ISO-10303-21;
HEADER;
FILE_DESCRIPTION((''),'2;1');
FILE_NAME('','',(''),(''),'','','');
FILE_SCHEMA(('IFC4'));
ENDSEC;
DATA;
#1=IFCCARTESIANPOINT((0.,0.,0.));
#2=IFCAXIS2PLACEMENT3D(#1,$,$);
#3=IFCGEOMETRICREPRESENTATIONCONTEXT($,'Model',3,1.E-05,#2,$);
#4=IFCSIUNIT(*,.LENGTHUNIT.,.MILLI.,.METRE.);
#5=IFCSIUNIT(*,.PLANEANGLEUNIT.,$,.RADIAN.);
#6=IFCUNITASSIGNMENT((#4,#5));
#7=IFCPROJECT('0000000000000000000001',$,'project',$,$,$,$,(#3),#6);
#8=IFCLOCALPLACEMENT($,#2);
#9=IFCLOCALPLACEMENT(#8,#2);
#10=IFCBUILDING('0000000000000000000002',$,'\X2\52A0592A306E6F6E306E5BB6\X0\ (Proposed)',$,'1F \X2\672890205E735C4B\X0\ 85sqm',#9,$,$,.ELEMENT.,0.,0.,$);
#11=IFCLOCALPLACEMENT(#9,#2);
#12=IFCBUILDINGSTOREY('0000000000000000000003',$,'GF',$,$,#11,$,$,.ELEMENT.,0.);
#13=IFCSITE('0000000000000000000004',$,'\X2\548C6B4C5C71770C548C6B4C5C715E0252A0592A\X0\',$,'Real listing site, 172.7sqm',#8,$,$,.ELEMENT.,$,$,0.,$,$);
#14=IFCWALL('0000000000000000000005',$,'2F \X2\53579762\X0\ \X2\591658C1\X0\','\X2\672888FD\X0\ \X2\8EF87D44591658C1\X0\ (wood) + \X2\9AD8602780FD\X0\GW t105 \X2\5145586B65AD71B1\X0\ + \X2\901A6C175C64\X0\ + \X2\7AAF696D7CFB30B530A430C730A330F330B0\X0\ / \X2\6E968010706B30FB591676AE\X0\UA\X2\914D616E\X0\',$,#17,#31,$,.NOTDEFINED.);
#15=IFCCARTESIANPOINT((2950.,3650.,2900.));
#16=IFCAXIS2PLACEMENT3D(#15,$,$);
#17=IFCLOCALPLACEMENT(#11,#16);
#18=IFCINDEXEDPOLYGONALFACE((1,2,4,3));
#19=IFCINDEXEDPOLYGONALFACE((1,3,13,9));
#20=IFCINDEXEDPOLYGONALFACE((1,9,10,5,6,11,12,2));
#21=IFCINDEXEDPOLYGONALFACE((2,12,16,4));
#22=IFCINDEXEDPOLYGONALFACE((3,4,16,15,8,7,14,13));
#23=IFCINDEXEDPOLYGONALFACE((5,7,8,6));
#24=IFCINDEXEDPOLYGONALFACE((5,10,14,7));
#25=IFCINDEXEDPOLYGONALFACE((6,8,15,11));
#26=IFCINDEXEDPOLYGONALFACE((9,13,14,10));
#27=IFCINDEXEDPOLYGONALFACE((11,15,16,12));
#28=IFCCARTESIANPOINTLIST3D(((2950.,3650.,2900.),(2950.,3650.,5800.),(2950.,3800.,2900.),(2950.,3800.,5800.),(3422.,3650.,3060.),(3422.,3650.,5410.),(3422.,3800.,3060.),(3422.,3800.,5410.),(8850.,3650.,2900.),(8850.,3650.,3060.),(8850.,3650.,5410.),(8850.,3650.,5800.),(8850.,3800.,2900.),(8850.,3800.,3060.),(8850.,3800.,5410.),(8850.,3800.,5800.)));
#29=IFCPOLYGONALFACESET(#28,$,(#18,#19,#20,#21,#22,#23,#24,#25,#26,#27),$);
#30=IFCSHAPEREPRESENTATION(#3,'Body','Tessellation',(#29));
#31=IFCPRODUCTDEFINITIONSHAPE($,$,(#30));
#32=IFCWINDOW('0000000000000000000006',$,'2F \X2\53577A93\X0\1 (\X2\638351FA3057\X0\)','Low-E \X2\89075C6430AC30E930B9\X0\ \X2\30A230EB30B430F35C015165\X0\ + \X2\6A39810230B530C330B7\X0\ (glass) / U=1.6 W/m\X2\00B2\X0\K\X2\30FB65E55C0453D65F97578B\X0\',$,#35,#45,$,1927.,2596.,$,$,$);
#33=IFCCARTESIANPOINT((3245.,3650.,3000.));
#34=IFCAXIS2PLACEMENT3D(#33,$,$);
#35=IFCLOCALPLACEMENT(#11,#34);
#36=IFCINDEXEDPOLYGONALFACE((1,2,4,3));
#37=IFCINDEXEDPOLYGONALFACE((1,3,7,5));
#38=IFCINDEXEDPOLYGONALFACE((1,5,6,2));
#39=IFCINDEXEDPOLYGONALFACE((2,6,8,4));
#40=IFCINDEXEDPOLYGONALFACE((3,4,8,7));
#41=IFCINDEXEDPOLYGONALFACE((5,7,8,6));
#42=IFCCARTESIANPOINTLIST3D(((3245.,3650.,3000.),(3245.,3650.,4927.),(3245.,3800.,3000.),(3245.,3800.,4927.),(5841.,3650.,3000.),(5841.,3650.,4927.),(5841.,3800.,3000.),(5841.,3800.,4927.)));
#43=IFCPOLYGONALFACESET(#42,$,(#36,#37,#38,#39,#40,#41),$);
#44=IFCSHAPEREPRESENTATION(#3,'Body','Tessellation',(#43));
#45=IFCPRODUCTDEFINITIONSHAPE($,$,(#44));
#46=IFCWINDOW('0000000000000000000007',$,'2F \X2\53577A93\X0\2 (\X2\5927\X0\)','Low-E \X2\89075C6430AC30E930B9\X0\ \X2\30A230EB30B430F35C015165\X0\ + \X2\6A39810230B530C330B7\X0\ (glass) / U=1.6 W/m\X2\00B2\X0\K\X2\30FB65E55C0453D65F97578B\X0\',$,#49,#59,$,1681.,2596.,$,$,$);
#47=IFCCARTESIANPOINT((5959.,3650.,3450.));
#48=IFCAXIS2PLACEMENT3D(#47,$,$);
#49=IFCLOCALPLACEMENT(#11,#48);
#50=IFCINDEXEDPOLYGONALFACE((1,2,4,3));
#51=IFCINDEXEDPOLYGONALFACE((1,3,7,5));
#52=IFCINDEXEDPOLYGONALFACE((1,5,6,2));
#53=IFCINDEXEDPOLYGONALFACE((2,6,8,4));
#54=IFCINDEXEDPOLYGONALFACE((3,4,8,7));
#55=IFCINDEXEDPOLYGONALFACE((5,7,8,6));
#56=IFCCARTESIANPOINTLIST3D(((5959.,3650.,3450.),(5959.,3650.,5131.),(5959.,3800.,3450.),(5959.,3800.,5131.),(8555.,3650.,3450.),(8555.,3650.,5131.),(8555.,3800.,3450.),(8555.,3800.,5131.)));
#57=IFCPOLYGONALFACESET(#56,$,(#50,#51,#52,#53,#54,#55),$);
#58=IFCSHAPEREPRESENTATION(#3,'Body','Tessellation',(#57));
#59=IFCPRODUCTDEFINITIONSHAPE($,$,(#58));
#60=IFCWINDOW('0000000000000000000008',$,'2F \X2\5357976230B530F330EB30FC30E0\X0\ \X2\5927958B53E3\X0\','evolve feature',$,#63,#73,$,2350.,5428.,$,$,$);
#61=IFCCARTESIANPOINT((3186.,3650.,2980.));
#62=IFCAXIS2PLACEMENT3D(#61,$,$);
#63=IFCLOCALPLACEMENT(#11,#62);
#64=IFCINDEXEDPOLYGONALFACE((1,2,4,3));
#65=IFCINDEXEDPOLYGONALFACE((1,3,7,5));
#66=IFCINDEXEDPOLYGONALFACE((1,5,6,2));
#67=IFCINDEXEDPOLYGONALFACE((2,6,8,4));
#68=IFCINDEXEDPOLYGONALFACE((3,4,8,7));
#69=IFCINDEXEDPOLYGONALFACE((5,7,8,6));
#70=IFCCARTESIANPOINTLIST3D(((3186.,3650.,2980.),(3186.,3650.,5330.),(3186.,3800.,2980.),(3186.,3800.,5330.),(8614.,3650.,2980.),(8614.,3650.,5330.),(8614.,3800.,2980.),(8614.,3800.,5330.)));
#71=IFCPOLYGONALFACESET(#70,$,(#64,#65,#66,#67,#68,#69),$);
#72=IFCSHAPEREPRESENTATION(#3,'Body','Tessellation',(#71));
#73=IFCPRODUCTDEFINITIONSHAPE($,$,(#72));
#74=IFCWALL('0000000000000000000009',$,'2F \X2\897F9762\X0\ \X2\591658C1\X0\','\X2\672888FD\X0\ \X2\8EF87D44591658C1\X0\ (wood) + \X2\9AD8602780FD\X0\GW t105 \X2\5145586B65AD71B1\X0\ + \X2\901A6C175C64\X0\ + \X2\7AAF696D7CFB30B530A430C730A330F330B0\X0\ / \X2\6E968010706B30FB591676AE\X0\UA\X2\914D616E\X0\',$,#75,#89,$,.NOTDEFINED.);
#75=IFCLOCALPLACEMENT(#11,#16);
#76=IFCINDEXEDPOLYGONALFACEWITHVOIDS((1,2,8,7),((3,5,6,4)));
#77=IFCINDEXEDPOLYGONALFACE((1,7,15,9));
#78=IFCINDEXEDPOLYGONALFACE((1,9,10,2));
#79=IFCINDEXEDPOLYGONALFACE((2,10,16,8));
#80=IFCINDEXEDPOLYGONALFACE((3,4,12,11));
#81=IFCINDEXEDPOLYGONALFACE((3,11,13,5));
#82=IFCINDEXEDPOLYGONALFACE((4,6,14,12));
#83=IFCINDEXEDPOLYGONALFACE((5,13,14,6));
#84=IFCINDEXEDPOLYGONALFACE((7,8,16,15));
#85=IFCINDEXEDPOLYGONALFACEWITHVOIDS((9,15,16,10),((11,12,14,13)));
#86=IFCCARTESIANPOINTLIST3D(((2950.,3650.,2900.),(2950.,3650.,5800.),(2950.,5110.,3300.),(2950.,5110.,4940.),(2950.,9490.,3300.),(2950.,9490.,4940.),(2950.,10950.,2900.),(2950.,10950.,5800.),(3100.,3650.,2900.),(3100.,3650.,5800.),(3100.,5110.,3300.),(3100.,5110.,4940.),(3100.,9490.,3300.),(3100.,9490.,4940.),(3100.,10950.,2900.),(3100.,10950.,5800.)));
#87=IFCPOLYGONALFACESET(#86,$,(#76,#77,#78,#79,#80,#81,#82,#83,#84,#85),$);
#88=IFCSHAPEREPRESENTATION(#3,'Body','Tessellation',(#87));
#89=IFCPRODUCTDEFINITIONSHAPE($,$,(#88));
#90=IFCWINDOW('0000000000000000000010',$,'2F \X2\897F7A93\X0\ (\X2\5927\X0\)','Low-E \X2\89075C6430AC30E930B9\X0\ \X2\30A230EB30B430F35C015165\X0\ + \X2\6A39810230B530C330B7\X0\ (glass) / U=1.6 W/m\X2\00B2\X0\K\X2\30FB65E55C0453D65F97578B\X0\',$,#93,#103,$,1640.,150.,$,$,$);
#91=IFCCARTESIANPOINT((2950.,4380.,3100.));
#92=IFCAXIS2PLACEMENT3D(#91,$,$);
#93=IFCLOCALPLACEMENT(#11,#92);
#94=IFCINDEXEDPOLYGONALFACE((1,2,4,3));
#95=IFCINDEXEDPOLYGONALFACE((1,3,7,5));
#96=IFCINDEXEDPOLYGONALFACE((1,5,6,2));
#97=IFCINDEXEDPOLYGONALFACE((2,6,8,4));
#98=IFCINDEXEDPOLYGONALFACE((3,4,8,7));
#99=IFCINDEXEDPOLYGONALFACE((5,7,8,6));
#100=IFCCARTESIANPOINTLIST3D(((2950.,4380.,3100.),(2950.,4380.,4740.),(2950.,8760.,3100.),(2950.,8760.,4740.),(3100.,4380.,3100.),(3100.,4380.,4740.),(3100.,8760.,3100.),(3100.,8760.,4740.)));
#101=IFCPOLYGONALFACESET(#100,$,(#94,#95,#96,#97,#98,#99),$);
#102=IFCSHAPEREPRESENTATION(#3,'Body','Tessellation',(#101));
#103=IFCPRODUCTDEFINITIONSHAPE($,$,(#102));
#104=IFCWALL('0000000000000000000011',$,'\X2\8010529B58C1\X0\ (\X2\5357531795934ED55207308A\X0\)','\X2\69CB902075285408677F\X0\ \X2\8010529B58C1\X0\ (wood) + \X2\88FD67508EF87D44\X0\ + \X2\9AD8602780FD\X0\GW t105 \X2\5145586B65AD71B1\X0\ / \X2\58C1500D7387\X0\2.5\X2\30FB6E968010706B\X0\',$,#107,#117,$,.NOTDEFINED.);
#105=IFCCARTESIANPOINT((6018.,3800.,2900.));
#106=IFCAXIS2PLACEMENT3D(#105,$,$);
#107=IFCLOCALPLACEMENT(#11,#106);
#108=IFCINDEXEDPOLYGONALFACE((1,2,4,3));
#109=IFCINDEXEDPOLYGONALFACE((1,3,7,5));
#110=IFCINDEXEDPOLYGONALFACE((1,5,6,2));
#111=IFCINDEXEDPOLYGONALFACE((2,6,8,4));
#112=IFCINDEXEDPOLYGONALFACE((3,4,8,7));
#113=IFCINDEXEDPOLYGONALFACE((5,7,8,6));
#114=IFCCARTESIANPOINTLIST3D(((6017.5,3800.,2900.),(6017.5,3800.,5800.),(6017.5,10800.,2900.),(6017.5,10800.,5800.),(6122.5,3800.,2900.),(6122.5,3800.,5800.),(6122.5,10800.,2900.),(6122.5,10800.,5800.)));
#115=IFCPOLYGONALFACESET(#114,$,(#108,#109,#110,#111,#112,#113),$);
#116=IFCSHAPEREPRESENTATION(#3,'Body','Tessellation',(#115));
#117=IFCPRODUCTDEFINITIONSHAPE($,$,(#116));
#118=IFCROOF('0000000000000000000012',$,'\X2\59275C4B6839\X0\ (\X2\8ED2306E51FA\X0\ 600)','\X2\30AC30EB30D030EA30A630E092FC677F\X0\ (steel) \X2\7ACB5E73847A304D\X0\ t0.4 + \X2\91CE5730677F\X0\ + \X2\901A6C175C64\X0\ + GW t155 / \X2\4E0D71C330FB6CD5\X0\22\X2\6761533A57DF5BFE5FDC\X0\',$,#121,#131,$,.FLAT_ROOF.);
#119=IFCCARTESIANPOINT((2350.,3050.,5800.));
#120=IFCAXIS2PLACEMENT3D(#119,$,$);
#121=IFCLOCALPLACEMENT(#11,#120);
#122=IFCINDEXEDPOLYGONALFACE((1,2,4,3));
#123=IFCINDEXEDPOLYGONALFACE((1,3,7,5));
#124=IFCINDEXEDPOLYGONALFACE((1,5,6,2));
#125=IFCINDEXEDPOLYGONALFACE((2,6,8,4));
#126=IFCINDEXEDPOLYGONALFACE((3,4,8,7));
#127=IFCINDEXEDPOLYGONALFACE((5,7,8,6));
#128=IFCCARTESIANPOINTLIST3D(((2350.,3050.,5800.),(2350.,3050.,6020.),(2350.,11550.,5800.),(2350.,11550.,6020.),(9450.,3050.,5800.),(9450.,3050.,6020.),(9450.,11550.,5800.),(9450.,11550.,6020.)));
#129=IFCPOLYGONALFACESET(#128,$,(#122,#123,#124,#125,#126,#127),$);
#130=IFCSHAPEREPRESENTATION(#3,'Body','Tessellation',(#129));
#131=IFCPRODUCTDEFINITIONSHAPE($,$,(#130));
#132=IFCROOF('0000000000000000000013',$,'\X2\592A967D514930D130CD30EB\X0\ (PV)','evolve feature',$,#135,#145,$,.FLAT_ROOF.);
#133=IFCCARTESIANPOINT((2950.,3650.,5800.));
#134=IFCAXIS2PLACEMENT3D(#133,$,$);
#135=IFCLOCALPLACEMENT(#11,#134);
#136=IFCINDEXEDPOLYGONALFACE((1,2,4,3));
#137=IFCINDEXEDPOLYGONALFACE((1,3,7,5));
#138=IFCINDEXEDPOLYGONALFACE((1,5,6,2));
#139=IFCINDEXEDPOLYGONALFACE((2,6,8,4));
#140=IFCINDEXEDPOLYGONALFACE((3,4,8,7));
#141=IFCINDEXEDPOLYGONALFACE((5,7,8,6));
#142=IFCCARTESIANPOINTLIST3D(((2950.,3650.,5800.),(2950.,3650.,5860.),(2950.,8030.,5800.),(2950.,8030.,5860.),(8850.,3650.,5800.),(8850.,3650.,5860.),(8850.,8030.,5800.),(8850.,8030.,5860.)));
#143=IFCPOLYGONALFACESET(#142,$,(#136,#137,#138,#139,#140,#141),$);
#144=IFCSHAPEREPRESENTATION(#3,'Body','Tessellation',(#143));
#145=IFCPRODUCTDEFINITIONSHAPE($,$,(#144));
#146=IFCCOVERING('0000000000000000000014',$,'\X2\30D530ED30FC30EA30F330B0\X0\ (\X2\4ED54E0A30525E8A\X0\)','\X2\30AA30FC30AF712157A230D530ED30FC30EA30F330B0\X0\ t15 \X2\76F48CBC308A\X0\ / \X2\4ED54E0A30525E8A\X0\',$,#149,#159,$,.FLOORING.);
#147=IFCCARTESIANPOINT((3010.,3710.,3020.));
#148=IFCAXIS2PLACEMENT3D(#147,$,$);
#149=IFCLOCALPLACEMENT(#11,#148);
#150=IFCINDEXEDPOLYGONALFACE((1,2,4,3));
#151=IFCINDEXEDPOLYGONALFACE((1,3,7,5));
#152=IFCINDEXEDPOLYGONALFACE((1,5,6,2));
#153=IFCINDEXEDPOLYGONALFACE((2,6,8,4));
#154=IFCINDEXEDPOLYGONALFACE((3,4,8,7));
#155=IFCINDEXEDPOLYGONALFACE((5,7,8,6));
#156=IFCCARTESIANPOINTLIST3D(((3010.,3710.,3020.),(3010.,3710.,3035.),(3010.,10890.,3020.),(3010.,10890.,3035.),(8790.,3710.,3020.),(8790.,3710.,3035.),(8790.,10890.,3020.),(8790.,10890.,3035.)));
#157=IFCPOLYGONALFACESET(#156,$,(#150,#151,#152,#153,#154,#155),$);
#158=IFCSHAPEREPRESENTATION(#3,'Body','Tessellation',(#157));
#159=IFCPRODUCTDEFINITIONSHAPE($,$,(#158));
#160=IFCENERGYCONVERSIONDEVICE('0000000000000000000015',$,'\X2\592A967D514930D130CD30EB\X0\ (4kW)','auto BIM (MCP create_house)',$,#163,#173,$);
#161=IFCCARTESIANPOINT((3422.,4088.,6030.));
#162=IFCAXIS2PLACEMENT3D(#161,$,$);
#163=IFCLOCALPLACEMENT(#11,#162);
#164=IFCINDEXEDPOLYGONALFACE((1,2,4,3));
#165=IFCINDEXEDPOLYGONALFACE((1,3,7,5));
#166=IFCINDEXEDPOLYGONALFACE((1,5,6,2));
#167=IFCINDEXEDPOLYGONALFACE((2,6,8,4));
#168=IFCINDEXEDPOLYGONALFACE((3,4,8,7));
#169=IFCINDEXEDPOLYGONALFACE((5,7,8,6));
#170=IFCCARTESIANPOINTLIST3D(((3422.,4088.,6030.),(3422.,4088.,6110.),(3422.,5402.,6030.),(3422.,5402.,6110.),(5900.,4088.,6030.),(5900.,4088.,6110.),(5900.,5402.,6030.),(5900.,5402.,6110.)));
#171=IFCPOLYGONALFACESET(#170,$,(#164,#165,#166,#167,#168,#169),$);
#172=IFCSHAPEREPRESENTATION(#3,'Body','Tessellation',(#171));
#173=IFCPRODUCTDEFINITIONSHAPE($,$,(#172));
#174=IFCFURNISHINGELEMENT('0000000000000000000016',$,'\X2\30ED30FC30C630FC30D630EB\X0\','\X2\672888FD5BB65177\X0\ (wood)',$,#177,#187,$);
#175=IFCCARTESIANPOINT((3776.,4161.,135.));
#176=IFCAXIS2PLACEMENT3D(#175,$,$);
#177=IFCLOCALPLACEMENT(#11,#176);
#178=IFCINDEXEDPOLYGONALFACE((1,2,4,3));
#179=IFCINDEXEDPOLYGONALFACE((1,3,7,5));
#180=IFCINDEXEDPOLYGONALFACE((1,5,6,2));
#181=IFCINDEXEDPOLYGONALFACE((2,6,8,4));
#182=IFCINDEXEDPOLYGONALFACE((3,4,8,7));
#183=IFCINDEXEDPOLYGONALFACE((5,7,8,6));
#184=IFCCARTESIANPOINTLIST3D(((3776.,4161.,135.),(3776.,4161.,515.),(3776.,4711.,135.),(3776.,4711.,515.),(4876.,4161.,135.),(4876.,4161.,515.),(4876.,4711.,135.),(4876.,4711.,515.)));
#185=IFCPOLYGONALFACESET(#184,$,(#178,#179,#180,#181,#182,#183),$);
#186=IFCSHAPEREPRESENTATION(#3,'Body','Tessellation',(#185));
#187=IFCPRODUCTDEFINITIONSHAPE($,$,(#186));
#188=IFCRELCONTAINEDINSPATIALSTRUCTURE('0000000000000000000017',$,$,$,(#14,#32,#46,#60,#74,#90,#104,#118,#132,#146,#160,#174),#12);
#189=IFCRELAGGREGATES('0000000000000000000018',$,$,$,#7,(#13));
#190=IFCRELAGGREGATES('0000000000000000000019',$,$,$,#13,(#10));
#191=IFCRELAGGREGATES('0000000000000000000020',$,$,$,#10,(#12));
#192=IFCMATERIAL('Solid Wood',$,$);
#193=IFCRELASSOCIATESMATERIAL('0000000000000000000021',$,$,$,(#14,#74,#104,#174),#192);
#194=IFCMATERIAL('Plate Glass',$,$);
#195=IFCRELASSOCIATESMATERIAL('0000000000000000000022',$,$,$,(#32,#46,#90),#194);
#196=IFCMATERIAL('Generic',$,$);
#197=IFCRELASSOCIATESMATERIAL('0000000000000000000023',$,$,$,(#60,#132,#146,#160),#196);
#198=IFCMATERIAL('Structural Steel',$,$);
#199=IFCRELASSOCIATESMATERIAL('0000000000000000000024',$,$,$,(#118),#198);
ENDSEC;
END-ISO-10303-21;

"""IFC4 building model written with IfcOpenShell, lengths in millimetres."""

from ifc_helpers import new_model, si_unit, frame, frame_2d, origin, place, context, project, spatial, rectangle, extrude, material, element, fill, save


model = new_model("IFC4")

# Units and contexts
model_context = context("Model", 3, precision=1e-05, world=origin())
ifc_project = project(units=[si_unit("LENGTHUNIT", "METRE", prefix="MILLI"), si_unit("PLANEANGLEUNIT", "RADIAN")], contexts=[model_context])

# Site, building, storey
site_placement = place(None, origin())
site = spatial("IfcSite", under=ifc_project, at=site_placement, Name="和歌山県和歌山市加太", ObjectType="Real listing site, 172.7sqm", CompositionType="ELEMENT", RefElevation=0.0)
building_placement = place(site_placement, origin())
building = spatial("IfcBuilding", under=site, at=building_placement, Name="加太の潮の家 (Proposed)", ObjectType="1F 木造平屋 85sqm", CompositionType="ELEMENT", ElevationOfRefHeight=0.0, ElevationOfTerrain=0.0)
storey_placement = place(building_placement, origin())
storey = spatial("IfcBuildingStorey", under=building, at=storey_placement, Name="GF", CompositionType="ELEMENT", Elevation=0.0)

# Shared definitions
ifc_material_1 = material(Name="Solid Wood")

# Wall, openings, windows
wall_1_placement = place(storey_placement, frame((2950.0, 3650.0, 2900.0)))
wall_1 = element("IfcWall", 1, at=wall_1_placement, inside=storey, material=ifc_material_1, Name="2F 南面 外壁", Description="木製 軸組外壁 (wood) + 高性能GW t105 充填断熱 + 通気層 + 窯業系サイディング / 準耐火・外皮UA配慮", PredefinedType="NOTDEFINED", context=model_context, shape_type="SweptSolid", body=[
    extrude(rectangle(XDim=5900.0, YDim=150.0, at=frame_2d((2950.0, 75.0))), frame((2950.0, 3650.0, 2900.0)), (0.0, 0.0, 1.0), 2900.0),
])
opening_1_placement = place(storey_placement, frame((3245.0, 3650.0, 3000.0)))
opening_1 = element("IfcOpeningElement", 2, at=opening_1_placement, cuts=wall_1, PredefinedType="NOTDEFINED", context=model_context, shape_type="SweptSolid", body=[
    extrude(rectangle(XDim=2596.0, YDim=150.0, at=frame_2d((1298.0, 75.0))), frame((3245.0, 3650.0, 3000.0)), (0.0, 0.0, 1.0), 1927.0),
])
opening_2_placement = place(storey_placement, frame((5959.0, 3650.0, 3450.0)))
opening_2 = element("IfcOpeningElement", 3, at=opening_2_placement, cuts=wall_1, PredefinedType="NOTDEFINED", context=model_context, shape_type="SweptSolid", body=[
    extrude(rectangle(XDim=2596.0, YDim=150.0, at=frame_2d((1298.0, 75.0))), frame((5959.0, 3650.0, 3450.0)), (0.0, 0.0, 1.0), 1681.0),
])
opening_3_placement = place(storey_placement, frame((3186.0, 3650.0, 2980.0)))
opening_3 = element("IfcOpeningElement", 4, at=opening_3_placement, cuts=wall_1, PredefinedType="NOTDEFINED", context=model_context, shape_type="SweptSolid", body=[
    extrude(rectangle(XDim=5428.0, YDim=150.0, at=frame_2d((2714.0, 75.0))), frame((3186.0, 3650.0, 2980.0)), (0.0, 0.0, 1.0), 2350.0),
])
ifc_material_2 = material(Name="Plate Glass")
window_1_placement = place(storey_placement, frame((3245.0, 3650.0, 3000.0)))
window_1 = element("IfcWindow", 5, at=window_1_placement, inside=storey, material=ifc_material_2, Name="2F 南窓1 (掃出し)", Description="Low-E 複層ガラス アルゴン封入 + 樹脂サッシ (glass) / U=1.6 W/m²K・日射取得型", OverallHeight=1927.0, OverallWidth=2596.0, context=model_context, shape_type="SweptSolid", body=[
    extrude(rectangle(XDim=2596.0, YDim=150.0, at=frame_2d((1298.0, 75.0))), frame((3245.0, 3650.0, 3000.0)), (0.0, 0.0, 1.0), 1927.0),
])
fill(opening_1, window_1)
window_2_placement = place(storey_placement, frame((5959.0, 3650.0, 3450.0)))
window_2 = element("IfcWindow", 6, at=window_2_placement, inside=storey, material=ifc_material_2, Name="2F 南窓2 (大)", Description="Low-E 複層ガラス アルゴン封入 + 樹脂サッシ (glass) / U=1.6 W/m²K・日射取得型", OverallHeight=1681.0, OverallWidth=2596.0, context=model_context, shape_type="SweptSolid", body=[
    extrude(rectangle(XDim=2596.0, YDim=150.0, at=frame_2d((1298.0, 75.0))), frame((5959.0, 3650.0, 3450.0)), (0.0, 0.0, 1.0), 1681.0),
])
fill(opening_2, window_2)
ifc_material_3 = material(Name="Generic")
window_3_placement = place(storey_placement, frame((3186.0, 3650.0, 2980.0)))
window_3 = element("IfcWindow", 7, at=window_3_placement, inside=storey, material=ifc_material_3, Name="2F 南面サンルーム 大開口", Description="evolve feature", OverallHeight=2350.0, OverallWidth=5428.0, context=model_context, shape_type="SweptSolid", body=[
    extrude(rectangle(XDim=5428.0, YDim=150.0, at=frame_2d((2714.0, 75.0))), frame((3186.0, 3650.0, 2980.0)), (0.0, 0.0, 1.0), 2350.0),
])
fill(opening_3, window_3)

# Wall, opening, window
wall_2_placement = place(storey_placement, frame((2950.0, 3650.0, 2900.0)))
wall_2 = element("IfcWall", 8, at=wall_2_placement, inside=storey, material=ifc_material_1, Name="2F 西面 外壁", Description="木製 軸組外壁 (wood) + 高性能GW t105 充填断熱 + 通気層 + 窯業系サイディング / 準耐火・外皮UA配慮", PredefinedType="NOTDEFINED", context=model_context, shape_type="SweptSolid", body=[
    extrude(rectangle(XDim=150.0, YDim=7300.0, at=frame_2d((75.0, 3650.0))), frame((2950.0, 3650.0, 2900.0)), (0.0, 0.0, 1.0), 2900.0),
])
opening_4_placement = place(storey_placement, frame((2950.0, 4380.0, 3100.0)))
opening_4 = element("IfcOpeningElement", 9, at=opening_4_placement, cuts=wall_2, PredefinedType="NOTDEFINED", context=model_context, shape_type="SweptSolid", body=[
    extrude(rectangle(XDim=150.0, YDim=4380.0, at=frame_2d((75.0, 2190.0))), frame((2950.0, 4380.0, 3100.0)), (0.0, 0.0, 1.0), 1640.0),
])
window_4_placement = place(storey_placement, frame((2950.0, 4380.0, 3100.0)))
window_4 = element("IfcWindow", 10, at=window_4_placement, inside=storey, material=ifc_material_2, Name="2F 西窓 (大)", Description="Low-E 複層ガラス アルゴン封入 + 樹脂サッシ (glass) / U=1.6 W/m²K・日射取得型", OverallHeight=1640.0, OverallWidth=150.0, context=model_context, shape_type="SweptSolid", body=[
    extrude(rectangle(XDim=150.0, YDim=4380.0, at=frame_2d((75.0, 2190.0))), frame((2950.0, 4380.0, 3100.0)), (0.0, 0.0, 1.0), 1640.0),
])
fill(opening_4, window_4)

# Wall
wall_3_placement = place(storey_placement, frame((6018.0, 3800.0, 2900.0)))
element("IfcWall", 11, at=wall_3_placement, inside=storey, material=ifc_material_1, Name="耐力壁 (南北間仕切り)", Description="構造用合板 耐力壁 (wood) + 製材軸組 + 高性能GW t105 充填断熱 / 壁倍率2.5・準耐火", PredefinedType="NOTDEFINED", context=model_context, shape_type="SweptSolid", body=[
    extrude(rectangle(XDim=105.0, YDim=7000.0, at=frame_2d((52.0, 3500.0))), frame((6018.0, 3800.0, 2900.0)), (0.0, 0.0, 1.0), 2900.0),
])

# Roofs
ifc_material_4 = material(Name="Structural Steel")
roof_1_placement = place(storey_placement, frame((2350.0, 3050.0, 5800.0)))
element("IfcRoof", 12, at=roof_1_placement, inside=storey, material=ifc_material_4, Name="大屋根 (軒の出 600)", Description="ガルバリウム鋼板 (steel) 立平葺き t0.4 + 野地板 + 通気層 + GW t155 / 不燃・法22条区域対応", PredefinedType="FLAT_ROOF", context=model_context, shape_type="SweptSolid", body=[
    extrude(rectangle(XDim=7100.0, YDim=8500.0, at=frame_2d((3550.0, 4250.0))), frame((2350.0, 3050.0, 5800.0)), (0.0, 0.0, 1.0), 220.0),
])
roof_2_placement = place(storey_placement, frame((2950.0, 3650.0, 5800.0)))
element("IfcRoof", 13, at=roof_2_placement, inside=storey, material=ifc_material_3, Name="太陽光パネル (PV)", Description="evolve feature", PredefinedType="FLAT_ROOF", context=model_context, shape_type="SweptSolid", body=[
    extrude(rectangle(XDim=5900.0, YDim=4380.0, at=frame_2d((2950.0, 2190.0))), frame((2950.0, 3650.0, 5800.0)), (0.0, 0.0, 1.0), 60.0),
])

# Covering
covering_placement = place(storey_placement, frame((3010.0, 3710.0, 3020.0)))
element("IfcCovering", 14, at=covering_placement, inside=storey, material=ifc_material_3, Name="フローリング (仕上げ床)", Description="オーク無垢フローリング t15 直貼り / 仕上げ床", PredefinedType="FLOORING", context=model_context, shape_type="SweptSolid", body=[
    extrude(rectangle(XDim=5780.0, YDim=7180.0, at=frame_2d((2890.0, 3590.0))), frame((3010.0, 3710.0, 3020.0)), (0.0, 0.0, 1.0), 15.0),
])

# Energy conversion device
energy_conversion_device_placement = place(storey_placement, frame((3422.0, 4088.0, 6030.0)))
element("IfcEnergyConversionDevice", 15, at=energy_conversion_device_placement, inside=storey, material=ifc_material_3, Name="太陽光パネル (4kW)", Description="auto BIM (MCP create_house)", context=model_context, shape_type="SweptSolid", body=[
    extrude(rectangle(XDim=2478.0, YDim=1314.0, at=frame_2d((1239.0, 657.0))), frame((3422.0, 4088.0, 6030.0)), (0.0, 0.0, 1.0), 80.0),
])

# Furnishing element
furnishing_1_placement = place(storey_placement, frame((3776.0, 4161.0, 135.0)))
element("IfcFurnishingElement", 16, at=furnishing_1_placement, inside=storey, material=ifc_material_1, Name="ローテーブル", Description="木製家具 (wood)", context=model_context, shape_type="SweptSolid", body=[
    extrude(rectangle(XDim=1100.0, YDim=550.0, at=frame_2d((550.0, 275.0))), frame((3776.0, 4161.0, 135.0)), (0.0, 0.0, 1.0), 380.0),
])

save(model, "model.ifc")
